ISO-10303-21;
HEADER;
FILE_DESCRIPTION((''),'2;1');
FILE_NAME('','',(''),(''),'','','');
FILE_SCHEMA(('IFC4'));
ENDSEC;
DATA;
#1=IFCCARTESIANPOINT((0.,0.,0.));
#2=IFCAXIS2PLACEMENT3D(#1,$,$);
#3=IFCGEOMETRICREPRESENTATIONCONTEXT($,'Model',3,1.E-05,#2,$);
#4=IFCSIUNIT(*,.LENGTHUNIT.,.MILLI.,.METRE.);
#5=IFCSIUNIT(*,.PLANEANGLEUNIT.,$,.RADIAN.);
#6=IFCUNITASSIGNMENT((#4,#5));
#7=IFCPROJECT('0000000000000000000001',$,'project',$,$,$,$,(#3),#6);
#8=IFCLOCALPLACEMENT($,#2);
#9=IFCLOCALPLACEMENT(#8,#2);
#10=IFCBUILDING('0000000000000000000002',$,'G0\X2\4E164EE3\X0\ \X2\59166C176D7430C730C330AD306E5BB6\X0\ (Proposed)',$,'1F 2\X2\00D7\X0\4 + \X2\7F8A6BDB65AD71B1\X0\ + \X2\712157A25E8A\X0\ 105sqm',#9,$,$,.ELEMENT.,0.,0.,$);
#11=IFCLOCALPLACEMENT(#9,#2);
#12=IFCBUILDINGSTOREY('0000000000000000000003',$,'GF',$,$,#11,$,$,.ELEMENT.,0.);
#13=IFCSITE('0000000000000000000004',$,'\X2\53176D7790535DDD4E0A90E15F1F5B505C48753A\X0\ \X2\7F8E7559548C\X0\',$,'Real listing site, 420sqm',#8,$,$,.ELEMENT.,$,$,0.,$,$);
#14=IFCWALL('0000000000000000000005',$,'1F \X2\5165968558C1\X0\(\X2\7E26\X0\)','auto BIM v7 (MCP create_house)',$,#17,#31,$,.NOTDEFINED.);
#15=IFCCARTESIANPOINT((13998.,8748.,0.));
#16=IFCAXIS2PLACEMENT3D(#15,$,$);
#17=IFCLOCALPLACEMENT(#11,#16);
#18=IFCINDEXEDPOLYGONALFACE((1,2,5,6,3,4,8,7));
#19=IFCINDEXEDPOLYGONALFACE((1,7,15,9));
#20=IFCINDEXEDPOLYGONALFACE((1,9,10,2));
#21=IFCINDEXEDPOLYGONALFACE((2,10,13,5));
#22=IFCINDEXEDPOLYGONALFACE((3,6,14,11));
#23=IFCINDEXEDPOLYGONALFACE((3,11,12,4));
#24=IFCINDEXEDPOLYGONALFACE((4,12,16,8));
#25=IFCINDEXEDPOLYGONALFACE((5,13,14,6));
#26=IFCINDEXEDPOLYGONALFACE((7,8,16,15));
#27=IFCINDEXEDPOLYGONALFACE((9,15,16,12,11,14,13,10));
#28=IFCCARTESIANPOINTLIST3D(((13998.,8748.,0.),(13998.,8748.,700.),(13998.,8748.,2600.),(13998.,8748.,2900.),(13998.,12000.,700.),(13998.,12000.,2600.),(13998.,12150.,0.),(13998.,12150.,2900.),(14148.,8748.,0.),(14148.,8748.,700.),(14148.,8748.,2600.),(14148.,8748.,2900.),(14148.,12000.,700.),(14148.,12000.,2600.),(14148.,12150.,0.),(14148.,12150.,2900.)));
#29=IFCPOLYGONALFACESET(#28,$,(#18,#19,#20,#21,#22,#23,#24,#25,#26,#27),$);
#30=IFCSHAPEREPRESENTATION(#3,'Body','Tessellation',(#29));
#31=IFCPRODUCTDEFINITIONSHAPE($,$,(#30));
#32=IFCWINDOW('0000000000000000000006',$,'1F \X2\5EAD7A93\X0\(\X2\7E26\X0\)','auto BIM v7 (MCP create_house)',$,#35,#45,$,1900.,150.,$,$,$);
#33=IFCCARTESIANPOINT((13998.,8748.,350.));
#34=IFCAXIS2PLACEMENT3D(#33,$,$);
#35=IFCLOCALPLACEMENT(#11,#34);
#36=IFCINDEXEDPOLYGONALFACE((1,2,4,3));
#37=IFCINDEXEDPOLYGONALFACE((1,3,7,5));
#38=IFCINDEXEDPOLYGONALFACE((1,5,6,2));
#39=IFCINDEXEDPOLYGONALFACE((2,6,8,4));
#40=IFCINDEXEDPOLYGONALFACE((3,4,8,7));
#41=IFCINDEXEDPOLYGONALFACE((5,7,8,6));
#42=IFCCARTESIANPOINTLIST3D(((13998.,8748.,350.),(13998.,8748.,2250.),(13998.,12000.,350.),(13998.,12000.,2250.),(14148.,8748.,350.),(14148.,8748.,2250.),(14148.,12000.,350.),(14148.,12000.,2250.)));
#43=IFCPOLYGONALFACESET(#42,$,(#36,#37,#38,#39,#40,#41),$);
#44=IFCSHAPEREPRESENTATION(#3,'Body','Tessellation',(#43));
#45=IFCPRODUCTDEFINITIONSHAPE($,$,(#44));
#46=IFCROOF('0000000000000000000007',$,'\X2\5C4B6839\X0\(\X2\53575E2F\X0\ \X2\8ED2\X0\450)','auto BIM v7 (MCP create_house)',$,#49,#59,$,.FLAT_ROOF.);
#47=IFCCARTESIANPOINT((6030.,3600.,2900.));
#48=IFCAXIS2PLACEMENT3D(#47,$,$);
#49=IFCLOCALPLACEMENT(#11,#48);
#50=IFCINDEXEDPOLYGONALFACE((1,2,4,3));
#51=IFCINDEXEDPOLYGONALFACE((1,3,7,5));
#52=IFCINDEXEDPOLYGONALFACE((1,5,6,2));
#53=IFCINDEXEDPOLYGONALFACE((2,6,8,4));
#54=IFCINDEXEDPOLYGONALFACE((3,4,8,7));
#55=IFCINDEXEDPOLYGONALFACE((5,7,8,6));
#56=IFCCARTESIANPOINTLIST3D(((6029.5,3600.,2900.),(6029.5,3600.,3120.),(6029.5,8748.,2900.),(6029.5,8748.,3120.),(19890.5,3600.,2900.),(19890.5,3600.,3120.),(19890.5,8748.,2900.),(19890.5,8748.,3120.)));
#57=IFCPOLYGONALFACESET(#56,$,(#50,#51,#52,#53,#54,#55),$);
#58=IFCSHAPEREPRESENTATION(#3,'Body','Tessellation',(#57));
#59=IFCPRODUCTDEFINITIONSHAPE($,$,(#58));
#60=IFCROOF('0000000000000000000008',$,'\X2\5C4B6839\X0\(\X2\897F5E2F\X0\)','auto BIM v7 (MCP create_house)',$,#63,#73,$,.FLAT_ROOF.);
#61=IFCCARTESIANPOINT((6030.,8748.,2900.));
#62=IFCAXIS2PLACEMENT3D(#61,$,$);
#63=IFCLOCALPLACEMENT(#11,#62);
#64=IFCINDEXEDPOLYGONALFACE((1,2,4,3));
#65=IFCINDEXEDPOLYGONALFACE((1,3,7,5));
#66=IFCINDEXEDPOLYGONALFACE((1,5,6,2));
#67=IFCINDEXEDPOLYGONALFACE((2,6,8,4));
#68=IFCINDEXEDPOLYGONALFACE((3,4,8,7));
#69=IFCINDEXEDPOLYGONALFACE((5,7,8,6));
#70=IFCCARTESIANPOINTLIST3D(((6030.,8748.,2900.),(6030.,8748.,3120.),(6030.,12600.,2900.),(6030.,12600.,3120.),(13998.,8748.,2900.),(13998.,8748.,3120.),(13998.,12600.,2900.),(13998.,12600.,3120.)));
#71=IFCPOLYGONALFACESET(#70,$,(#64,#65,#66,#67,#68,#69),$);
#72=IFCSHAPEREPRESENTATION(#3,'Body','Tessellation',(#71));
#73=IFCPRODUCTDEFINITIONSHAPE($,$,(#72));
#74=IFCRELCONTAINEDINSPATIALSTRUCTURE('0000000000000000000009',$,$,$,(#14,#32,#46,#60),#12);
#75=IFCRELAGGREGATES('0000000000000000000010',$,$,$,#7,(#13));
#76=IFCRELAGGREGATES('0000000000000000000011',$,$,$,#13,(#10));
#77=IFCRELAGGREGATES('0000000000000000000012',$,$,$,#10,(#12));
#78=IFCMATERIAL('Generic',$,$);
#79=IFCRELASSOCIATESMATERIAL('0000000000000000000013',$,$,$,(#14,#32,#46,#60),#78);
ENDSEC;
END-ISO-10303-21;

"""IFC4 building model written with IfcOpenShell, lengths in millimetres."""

from ifc_helpers import new_model, si_unit, frame, frame_2d, origin, place, context, project, spatial, rectangle, extrude, material, element, fill, save


model = new_model("IFC4")

# Units and contexts
model_context = context("Model", 3, precision=1e-05, world=origin())
ifc_project = project(units=[si_unit("LENGTHUNIT", "METRE", prefix="MILLI"), si_unit("PLANEANGLEUNIT", "RADIAN")], contexts=[model_context])

# Site, building, storey
site_placement = place(None, origin())
site = spatial("IfcSite", under=ifc_project, at=site_placement, Name="北海道川上郡弟子屈町 美留和", ObjectType="Real listing site, 420sqm", CompositionType="ELEMENT", RefElevation=0.0)
building_placement = place(site_placement, origin())
building = spatial("IfcBuilding", under=site, at=building_placement, Name="G0世代 外気浴デッキの家 (Proposed)", ObjectType="1F 2×4 + 羊毛断熱 + 無垢床 105sqm", CompositionType="ELEMENT", ElevationOfRefHeight=0.0, ElevationOfTerrain=0.0)
storey_placement = place(building_placement, origin())
storey = spatial("IfcBuildingStorey", under=building, at=storey_placement, Name="GF", CompositionType="ELEMENT", Elevation=0.0)

# Shared definitions
ifc_material = material(Name="Generic")

# Wall, opening, window
wall_1_placement = place(storey_placement, frame((13998.0, 8748.0, 0.0)))
wall_1 = element("IfcWall", 1, at=wall_1_placement, inside=storey, material=ifc_material, Name="1F 入隅壁(縦)", Description="auto BIM v7 (MCP create_house)", PredefinedType="NOTDEFINED", context=model_context, shape_type="SweptSolid", body=[
    extrude(rectangle(XDim=150.0, YDim=3402.0, at=frame_2d((75.0, 1701.0))), frame((13998.0, 8748.0, 0.0)), (0.0, 0.0, 1.0), 2900.0),
])
opening_1_placement = place(storey_placement, frame((13998.0, 8748.0, 350.0)))
opening_1 = element("IfcOpeningElement", 2, at=opening_1_placement, cuts=wall_1, PredefinedType="NOTDEFINED", context=model_context, shape_type="SweptSolid", body=[
    extrude(rectangle(XDim=150.0, YDim=3252.0, at=frame_2d((75.0, 1626.0))), frame((13998.0, 8748.0, 350.0)), (0.0, 0.0, 1.0), 1900.0),
])
window_1_placement = place(storey_placement, frame((13998.0, 8748.0, 350.0)))
window_1 = element("IfcWindow", 3, at=window_1_placement, inside=storey, material=ifc_material, Name="1F 庭窓(縦)", Description="auto BIM v7 (MCP create_house)", OverallHeight=1900.0, OverallWidth=150.0, context=model_context, shape_type="SweptSolid", body=[
    extrude(rectangle(XDim=150.0, YDim=3252.0, at=frame_2d((75.0, 1626.0))), frame((13998.0, 8748.0, 350.0)), (0.0, 0.0, 1.0), 1900.0),
])
fill(opening_1, window_1)

# Roofs
roof_1_placement = place(storey_placement, frame((6030.0, 3600.0, 2900.0)))
element("IfcRoof", 4, at=roof_1_placement, inside=storey, material=ifc_material, Name="屋根(南帯 軒450)", Description="auto BIM v7 (MCP create_house)", PredefinedType="FLAT_ROOF", context=model_context, shape_type="SweptSolid", body=[
    extrude(rectangle(XDim=13861.0, YDim=5148.0, at=frame_2d((6930.0, 2574.0))), frame((6030.0, 3600.0, 2900.0)), (0.0, 0.0, 1.0), 220.0),
])
roof_2_placement = place(storey_placement, frame((6030.0, 8748.0, 2900.0)))
element("IfcRoof", 5, at=roof_2_placement, inside=storey, material=ifc_material, Name="屋根(西帯)", Description="auto BIM v7 (MCP create_house)", PredefinedType="FLAT_ROOF", context=model_context, shape_type="SweptSolid", body=[
    extrude(rectangle(XDim=7968.0, YDim=3852.0, at=frame_2d((3984.0, 1926.0))), frame((6030.0, 8748.0, 2900.0)), (0.0, 0.0, 1.0), 220.0),
])

save(model, "model.ifc")
